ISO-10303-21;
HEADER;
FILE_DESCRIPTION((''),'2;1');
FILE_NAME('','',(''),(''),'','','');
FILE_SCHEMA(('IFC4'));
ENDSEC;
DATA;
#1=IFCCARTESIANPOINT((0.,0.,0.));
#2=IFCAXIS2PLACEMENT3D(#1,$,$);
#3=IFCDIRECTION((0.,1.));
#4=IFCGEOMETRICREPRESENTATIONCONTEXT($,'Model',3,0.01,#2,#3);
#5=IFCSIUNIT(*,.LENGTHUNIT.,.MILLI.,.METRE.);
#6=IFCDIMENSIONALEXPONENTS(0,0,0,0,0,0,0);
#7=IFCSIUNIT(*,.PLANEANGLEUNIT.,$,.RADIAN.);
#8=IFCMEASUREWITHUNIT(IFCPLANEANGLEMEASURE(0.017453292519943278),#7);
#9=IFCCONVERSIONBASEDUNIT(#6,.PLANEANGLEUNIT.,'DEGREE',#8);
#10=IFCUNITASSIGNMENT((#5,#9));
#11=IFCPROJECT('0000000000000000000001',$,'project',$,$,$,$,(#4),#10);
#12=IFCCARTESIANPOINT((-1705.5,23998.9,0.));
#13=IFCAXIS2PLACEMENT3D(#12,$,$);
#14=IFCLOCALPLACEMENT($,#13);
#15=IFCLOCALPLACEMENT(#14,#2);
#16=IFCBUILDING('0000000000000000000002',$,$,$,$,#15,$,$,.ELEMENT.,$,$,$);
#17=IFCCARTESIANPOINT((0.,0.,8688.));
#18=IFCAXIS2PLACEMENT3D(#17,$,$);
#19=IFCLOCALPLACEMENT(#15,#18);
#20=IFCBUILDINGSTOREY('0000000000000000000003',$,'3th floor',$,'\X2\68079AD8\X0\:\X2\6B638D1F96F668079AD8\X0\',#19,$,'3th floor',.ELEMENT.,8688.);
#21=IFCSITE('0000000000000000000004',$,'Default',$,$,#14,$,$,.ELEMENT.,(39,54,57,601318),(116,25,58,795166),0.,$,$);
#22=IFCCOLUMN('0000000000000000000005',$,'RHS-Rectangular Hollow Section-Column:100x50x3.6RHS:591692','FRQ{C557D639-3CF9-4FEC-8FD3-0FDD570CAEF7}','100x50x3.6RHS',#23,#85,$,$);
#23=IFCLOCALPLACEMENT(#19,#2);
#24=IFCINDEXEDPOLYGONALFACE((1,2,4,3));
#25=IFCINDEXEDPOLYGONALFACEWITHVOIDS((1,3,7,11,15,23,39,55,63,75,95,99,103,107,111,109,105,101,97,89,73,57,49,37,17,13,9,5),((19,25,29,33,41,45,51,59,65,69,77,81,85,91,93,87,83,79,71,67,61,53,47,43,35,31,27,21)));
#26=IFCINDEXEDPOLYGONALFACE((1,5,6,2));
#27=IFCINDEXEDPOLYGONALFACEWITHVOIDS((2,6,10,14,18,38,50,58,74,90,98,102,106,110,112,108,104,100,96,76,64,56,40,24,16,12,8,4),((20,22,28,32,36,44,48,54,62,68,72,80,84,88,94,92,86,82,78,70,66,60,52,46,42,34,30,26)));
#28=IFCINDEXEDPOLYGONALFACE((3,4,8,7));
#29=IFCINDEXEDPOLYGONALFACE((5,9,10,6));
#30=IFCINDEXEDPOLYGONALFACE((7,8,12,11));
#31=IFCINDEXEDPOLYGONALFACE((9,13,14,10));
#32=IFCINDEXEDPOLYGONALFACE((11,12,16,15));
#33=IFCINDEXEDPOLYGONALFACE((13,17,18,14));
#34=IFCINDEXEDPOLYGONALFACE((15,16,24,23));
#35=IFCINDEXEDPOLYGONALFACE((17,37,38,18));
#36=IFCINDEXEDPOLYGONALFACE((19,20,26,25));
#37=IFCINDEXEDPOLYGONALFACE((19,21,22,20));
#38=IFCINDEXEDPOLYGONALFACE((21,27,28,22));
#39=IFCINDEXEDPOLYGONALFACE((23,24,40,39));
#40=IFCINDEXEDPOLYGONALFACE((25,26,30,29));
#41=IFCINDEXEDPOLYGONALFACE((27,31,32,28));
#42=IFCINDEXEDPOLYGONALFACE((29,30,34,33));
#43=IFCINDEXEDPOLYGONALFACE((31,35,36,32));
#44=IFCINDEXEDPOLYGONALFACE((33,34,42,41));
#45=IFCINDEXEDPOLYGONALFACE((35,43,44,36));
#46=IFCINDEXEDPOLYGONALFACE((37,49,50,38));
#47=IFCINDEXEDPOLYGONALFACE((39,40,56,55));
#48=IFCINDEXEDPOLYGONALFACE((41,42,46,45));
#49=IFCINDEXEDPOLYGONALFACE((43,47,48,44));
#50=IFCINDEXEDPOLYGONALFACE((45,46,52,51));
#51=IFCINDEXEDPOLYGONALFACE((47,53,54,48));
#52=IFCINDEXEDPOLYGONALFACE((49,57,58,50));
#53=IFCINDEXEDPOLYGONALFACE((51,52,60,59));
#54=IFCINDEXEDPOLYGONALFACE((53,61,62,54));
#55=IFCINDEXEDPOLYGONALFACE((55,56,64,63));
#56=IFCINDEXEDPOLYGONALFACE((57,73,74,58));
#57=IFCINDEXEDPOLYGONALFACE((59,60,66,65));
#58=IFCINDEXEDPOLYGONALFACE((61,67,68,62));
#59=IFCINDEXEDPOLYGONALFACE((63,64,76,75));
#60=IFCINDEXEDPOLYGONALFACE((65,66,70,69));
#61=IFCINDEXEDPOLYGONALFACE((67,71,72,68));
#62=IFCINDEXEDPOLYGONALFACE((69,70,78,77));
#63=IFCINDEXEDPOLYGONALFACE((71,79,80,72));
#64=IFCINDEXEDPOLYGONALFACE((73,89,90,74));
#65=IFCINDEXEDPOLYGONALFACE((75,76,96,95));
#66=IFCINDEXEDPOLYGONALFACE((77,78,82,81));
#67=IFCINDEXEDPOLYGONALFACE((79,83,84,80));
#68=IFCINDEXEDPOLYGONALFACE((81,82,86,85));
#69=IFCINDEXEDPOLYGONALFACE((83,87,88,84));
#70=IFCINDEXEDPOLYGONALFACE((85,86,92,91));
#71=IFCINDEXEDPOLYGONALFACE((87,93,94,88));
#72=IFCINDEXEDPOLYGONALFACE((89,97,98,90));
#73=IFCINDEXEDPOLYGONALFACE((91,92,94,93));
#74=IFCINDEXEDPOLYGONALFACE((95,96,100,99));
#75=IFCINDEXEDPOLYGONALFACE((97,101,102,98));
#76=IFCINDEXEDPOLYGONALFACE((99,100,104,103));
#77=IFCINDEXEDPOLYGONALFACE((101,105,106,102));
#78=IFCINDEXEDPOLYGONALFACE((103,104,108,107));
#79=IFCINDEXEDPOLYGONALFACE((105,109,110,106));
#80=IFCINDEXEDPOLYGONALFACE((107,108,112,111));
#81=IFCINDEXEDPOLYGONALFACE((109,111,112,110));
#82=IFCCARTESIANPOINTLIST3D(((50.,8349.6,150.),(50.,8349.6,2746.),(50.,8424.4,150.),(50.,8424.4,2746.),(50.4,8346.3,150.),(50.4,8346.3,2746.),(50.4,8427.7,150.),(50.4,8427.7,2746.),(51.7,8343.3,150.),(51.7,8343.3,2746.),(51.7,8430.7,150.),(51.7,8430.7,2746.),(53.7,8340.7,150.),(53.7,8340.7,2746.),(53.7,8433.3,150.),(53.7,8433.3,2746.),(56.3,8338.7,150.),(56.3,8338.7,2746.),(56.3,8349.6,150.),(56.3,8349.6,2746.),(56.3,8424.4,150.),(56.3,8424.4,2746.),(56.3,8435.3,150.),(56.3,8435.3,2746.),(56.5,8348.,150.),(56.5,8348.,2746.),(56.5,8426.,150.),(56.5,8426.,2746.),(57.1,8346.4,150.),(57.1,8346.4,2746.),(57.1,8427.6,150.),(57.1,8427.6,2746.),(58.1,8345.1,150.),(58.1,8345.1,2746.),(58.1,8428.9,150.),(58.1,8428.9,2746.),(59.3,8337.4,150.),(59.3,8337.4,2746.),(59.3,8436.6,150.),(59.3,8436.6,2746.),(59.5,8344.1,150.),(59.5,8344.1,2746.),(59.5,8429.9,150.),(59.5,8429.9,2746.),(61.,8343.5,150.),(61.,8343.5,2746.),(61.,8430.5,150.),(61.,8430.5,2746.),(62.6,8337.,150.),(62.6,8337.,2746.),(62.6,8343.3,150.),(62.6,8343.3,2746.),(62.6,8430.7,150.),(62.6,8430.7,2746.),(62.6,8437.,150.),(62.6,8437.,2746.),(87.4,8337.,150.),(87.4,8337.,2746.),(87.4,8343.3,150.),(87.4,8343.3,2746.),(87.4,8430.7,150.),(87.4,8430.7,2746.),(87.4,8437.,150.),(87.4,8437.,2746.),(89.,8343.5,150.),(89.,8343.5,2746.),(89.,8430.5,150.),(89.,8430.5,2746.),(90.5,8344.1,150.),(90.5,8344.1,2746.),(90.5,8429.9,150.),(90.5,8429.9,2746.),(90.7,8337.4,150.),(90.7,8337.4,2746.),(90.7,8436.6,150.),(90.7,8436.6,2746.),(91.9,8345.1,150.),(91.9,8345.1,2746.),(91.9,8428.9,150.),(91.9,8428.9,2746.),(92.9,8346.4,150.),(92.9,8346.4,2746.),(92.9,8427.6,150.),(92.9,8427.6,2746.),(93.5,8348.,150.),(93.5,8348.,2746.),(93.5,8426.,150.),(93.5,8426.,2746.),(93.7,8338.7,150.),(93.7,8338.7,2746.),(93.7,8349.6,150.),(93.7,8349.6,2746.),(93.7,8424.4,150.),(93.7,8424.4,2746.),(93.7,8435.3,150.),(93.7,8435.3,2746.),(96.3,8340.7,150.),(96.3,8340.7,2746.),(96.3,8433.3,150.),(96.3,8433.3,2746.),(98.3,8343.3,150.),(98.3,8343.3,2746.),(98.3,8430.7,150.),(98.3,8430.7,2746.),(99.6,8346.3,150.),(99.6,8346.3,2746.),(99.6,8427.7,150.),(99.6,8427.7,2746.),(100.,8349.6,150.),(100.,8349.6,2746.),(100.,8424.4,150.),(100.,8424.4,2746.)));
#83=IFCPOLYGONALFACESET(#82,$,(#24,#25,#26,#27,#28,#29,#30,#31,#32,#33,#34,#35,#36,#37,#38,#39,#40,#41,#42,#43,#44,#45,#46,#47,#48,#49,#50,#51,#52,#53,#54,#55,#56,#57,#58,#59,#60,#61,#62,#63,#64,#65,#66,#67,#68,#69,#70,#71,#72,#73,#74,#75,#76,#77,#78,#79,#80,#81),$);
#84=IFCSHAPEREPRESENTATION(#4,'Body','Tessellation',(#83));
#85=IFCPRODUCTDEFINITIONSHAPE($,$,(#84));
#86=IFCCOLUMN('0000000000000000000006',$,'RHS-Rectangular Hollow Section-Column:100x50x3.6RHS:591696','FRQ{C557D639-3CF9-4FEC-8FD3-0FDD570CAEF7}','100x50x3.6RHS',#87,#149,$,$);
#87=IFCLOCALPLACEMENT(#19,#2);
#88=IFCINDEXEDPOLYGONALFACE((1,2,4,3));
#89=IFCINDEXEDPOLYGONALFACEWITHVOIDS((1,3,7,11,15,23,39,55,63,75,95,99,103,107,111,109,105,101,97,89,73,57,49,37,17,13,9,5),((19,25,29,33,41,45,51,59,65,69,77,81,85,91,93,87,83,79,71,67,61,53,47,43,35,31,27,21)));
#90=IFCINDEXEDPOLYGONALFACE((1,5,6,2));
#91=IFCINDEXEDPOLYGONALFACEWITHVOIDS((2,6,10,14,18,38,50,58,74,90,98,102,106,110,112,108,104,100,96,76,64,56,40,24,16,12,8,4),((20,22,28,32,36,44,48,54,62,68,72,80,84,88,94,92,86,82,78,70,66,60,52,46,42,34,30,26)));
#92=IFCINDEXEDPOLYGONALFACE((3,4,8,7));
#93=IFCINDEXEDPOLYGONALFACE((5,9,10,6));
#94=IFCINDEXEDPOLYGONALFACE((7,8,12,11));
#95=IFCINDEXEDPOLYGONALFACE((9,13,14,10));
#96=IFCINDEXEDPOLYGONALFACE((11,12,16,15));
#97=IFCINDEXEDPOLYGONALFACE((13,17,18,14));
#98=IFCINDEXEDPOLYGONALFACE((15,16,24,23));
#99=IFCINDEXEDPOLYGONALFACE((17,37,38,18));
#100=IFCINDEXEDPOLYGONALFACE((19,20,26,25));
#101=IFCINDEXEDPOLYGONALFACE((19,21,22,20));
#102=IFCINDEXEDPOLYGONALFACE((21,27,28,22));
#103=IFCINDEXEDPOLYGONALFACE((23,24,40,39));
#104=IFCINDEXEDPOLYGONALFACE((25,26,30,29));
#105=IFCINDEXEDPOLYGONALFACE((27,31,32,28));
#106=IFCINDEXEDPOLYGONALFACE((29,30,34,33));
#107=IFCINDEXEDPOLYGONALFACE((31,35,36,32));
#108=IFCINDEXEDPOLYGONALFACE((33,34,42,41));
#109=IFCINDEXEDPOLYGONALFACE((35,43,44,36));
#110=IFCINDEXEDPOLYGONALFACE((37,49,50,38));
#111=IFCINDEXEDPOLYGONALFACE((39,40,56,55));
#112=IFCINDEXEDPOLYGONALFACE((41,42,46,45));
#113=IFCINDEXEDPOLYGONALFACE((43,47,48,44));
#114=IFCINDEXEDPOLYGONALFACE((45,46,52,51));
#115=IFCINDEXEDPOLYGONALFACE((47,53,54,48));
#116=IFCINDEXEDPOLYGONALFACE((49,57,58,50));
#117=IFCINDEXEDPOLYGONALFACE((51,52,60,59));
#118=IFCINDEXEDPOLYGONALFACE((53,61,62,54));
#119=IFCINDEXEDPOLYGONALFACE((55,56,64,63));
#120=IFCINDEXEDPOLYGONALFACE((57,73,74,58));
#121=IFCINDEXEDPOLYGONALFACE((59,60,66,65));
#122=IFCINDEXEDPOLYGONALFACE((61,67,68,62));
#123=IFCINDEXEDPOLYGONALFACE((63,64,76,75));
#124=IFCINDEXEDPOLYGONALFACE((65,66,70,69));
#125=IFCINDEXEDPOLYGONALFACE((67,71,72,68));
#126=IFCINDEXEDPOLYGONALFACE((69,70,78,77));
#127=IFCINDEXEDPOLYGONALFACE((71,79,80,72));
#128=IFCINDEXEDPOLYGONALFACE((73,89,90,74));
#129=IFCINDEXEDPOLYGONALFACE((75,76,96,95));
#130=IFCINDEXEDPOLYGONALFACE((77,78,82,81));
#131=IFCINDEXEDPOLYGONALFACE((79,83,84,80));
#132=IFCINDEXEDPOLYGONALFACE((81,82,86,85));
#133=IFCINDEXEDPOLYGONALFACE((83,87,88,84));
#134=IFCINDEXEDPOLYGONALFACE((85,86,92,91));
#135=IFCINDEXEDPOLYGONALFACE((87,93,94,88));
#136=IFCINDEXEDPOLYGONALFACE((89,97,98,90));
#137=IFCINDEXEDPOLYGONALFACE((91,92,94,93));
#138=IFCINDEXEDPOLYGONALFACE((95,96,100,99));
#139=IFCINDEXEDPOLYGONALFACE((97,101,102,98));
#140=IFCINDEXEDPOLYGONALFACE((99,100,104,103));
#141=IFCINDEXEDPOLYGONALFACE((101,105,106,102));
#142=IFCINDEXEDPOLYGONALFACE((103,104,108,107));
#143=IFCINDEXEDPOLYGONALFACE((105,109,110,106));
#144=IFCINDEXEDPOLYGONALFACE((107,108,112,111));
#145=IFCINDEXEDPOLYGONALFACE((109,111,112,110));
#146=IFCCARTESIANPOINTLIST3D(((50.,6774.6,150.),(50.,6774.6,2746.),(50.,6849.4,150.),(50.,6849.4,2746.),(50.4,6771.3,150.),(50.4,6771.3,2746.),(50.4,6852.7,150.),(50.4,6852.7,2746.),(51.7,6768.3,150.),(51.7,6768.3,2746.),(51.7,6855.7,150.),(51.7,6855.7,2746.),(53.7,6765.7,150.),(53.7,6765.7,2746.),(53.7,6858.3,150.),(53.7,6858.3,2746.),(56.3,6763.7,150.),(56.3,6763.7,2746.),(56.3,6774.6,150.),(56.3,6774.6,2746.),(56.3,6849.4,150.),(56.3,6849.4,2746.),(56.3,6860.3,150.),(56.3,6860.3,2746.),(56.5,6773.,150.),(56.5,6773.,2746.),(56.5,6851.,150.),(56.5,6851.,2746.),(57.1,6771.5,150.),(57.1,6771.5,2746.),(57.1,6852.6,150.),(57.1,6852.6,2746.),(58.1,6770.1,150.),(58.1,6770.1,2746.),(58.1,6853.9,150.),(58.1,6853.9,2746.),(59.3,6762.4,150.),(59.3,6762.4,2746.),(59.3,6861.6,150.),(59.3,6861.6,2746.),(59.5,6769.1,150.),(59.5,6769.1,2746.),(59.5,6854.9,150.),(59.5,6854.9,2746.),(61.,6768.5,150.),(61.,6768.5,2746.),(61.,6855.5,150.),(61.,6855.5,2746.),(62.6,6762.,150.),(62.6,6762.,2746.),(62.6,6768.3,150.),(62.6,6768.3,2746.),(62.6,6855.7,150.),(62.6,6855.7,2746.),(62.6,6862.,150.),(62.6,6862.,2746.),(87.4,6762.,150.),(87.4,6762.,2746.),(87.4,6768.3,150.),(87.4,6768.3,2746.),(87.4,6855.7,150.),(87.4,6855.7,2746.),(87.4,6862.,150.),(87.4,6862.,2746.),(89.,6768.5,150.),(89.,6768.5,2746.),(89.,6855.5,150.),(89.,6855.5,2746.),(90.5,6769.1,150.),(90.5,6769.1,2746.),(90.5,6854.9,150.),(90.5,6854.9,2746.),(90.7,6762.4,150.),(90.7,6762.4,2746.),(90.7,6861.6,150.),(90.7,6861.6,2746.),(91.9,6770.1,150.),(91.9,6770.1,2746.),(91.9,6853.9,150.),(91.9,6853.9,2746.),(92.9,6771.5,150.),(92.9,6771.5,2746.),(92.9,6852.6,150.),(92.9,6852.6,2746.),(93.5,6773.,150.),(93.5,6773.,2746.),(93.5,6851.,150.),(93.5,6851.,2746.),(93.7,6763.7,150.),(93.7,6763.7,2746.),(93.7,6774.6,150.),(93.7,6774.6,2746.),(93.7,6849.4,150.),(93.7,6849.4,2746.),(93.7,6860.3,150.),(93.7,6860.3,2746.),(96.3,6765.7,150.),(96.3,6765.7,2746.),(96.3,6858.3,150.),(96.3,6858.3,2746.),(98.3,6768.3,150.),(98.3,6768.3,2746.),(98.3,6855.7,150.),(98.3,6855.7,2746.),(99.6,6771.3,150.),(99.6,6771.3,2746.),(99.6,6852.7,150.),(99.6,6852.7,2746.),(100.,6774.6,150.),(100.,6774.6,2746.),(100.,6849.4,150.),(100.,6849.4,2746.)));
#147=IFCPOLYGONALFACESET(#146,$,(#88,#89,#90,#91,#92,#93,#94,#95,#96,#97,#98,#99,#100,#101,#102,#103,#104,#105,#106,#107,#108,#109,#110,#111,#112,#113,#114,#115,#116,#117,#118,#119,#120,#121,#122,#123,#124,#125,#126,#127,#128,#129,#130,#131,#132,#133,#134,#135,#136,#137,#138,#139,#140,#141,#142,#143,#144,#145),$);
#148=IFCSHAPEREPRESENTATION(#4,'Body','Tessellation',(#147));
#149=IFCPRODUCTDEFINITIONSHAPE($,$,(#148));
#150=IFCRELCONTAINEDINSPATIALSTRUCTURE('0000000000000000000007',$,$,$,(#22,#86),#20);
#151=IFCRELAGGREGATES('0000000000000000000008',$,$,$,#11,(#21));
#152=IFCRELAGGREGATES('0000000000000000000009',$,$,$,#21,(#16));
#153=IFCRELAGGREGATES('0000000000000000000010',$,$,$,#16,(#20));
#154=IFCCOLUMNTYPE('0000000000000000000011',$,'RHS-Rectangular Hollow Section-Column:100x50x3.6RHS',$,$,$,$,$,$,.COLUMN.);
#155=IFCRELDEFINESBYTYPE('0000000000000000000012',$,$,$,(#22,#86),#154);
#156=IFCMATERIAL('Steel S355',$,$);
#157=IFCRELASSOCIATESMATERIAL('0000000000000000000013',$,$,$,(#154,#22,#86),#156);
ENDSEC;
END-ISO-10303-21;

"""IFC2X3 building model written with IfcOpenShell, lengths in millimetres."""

from ifc_helpers import new_model, entity, si_unit, converted_unit, point, direction, frame, frame_2d, origin, origin_2d, place, context, project, spatial, circle_curve, line_curve, trimmed, segment, composite_curve, hollow_rectangle, outline, extrude, clip, halfspace, material, type_object, element, save


model = new_model("IFC2X3")

# Units and contexts
model_context = context("Model", 3, precision=0.01, world=origin(), true_north=direction((0.0, 1.0)))
ifc_project = project(units=[si_unit("LENGTHUNIT", "METRE", prefix="MILLI"), converted_unit("PLANEANGLEUNIT", "DEGREE", entity("IfcPlaneAngleMeasure", 0.017453292519943278), si_unit("PLANEANGLEUNIT", "RADIAN"), dimensions=[0, 0, 0, 0, 0, 0, 0])], contexts=[model_context])

# Site, building, storey
site_placement = place(None, frame((-1705.5, 23998.9, 0.0)))
site = spatial("IfcSite", under=ifc_project, at=site_placement, Name="Default", CompositionType="ELEMENT", RefLatitude=(39, 54, 57, 601318), RefLongitude=(116, 25, 58, 795166), RefElevation=0.0)
building_placement = place(site_placement, origin())
building = spatial("IfcBuilding", under=site, at=building_placement, CompositionType="ELEMENT")
storey_placement = place(building_placement, frame((0.0, 0.0, 8688.0)))
storey = spatial("IfcBuildingStorey", under=building, at=storey_placement, Name="3th floor", ObjectType="标高:正负零标高", LongName="3th floor", CompositionType="ELEMENT", Elevation=8688.0)

# Columns, openings
ifc_material_1 = material(Name="Steel S355")
column_type_1 = type_object("IfcColumnType", Name="RHS-Rectangular Hollow Section-Column:100x50x3.6RHS", PredefinedType="COLUMN", material=ifc_material_1)
column_1_placement = place(storey_placement, frame((75.0, 8387.0, 2876.9)))
column_1 = element("IfcColumn", 1, at=column_1_placement, inside=storey, type_object=column_type_1, material=ifc_material_1, Name="RHS-Rectangular Hollow Section-Column:100x50x3.6RHS:591692", Description="FRQ{C557D639-3CF9-4FEC-8FD3-0FDD570CAEF7}", ObjectType="100x50x3.6RHS", context=model_context, shape_type="Clipping", body=[
    clip(clip(extrude(hollow_rectangle(XDim=50.0, YDim=100.0, WallThickness=6.3, InnerFilletRadius=6.3, OuterFilletRadius=12.6, at=origin_2d()), origin(), (0.0, 0.0, -1.0), 2782.8), halfspace(frame((-75.0, -8387.0, -2726.9), z_axis=(0.0, 0.0, 1.0), x_axis=(1.0, 0.0, 0.0)), True)), halfspace(frame((-75.0, -8387.0, -55.9), z_axis=(0.0, 0.0, -1.0), x_axis=(-1.0, 0.0, 0.0)), True)),
])
opening_1_placement = place(column_1_placement, frame((0.0, -150.1, -130.9), z_axis=(0.0, 1.0, 0.0), x_axis=(-1.0, 0.0, 0.0)))
element("IfcOpeningElement", 2, at=opening_1_placement, cuts=column_1, ObjectType="Opening", context=model_context, shape_type="SweptSolid", body=[
    extrude(outline(composite_curve([segment(trimmed(circle_curve(frame_2d((43.0, 32.0), x_axis=(1.0, 0.0)), 32.0), [point((43.0, 0.0))], [point((75.0, 32.0))], True, "CARTESIAN"), True, "CONTINUOUS"), segment(trimmed(line_curve((75.0, 32.0), (0.0, 1.0), 86.0), [point((75.0, 32.0))], [point((75.0, 118.0))], True, "CARTESIAN"), True, "CONTINUOUS"), segment(trimmed(circle_curve(frame_2d((43.0, 118.0), x_axis=(1.0, 0.0)), 32.0), [point((75.0, 118.0))], [point((43.0, 150.0))], True, "CARTESIAN"), True, "CONTINUOUS"), segment(trimmed(line_curve((43.0, 150.0), (-1.0, 0.0), 86.0), [point((43.0, 150.0))], [point((-43.0, 150.0))], True, "CARTESIAN"), True, "CONTINUOUS"), segment(trimmed(circle_curve(frame_2d((-43.0, 118.0), x_axis=(1.0, 0.0)), 32.0), [point((-43.0, 150.0))], [point((-75.0, 118.0))], True, "CARTESIAN"), True, "CONTINUOUS"), segment(trimmed(line_curve((-75.0, 118.0), (0.0, -1.0), 86.0), [point((-75.0, 118.0))], [point((-75.0, 32.0))], True, "CARTESIAN"), True, "CONTINUOUS"), segment(trimmed(circle_curve(frame_2d((-43.0, 32.0), x_axis=(1.0, 0.0)), 32.0), [point((-75.0, 32.0))], [point((-43.0, 0.0))], True, "CARTESIAN"), True, "CONTINUOUS"), segment(trimmed(line_curve((-43.0, 0.0), (1.0, 0.0), 86.0), [point((-43.0, 0.0))], [point((43.0, 0.0))], True, "CARTESIAN"), True, "CONTINUOUS")], self_intersect="UNKNOWN")), origin(), (0.0, 0.0, 1.0), 300.2),
])
column_2_placement = place(storey_placement, frame((75.0, 6812.0, 2876.9)))
column_2 = element("IfcColumn", 3, at=column_2_placement, inside=storey, type_object=column_type_1, material=ifc_material_1, Name="RHS-Rectangular Hollow Section-Column:100x50x3.6RHS:591696", Description="FRQ{C557D639-3CF9-4FEC-8FD3-0FDD570CAEF7}", ObjectType="100x50x3.6RHS", context=model_context, shape_type="Clipping", body=[
    clip(clip(extrude(hollow_rectangle(XDim=50.0, YDim=100.0, WallThickness=6.3, InnerFilletRadius=6.3, OuterFilletRadius=12.6, at=origin_2d()), origin(), (0.0, 0.0, -1.0), 2782.8), halfspace(frame((-75.0, -6812.0, -2726.9), z_axis=(0.0, 0.0, 1.0), x_axis=(1.0, 0.0, 0.0)), True)), halfspace(frame((-75.0, -6812.0, -55.9), z_axis=(0.0, 0.0, -1.0), x_axis=(-1.0, 0.0, 0.0)), True)),
])
opening_2_placement = place(column_2_placement, frame((0.0, -150.1, -130.9), z_axis=(0.0, 1.0, 0.0), x_axis=(-1.0, 0.0, 0.0)))
element("IfcOpeningElement", 4, at=opening_2_placement, cuts=column_2, ObjectType="Opening", context=model_context, shape_type="SweptSolid", body=[
    extrude(outline(composite_curve([segment(trimmed(circle_curve(frame_2d((43.0, 32.0), x_axis=(1.0, 0.0)), 32.0), [point((43.0, 0.0))], [point((75.0, 32.0))], True, "CARTESIAN"), True, "CONTINUOUS"), segment(trimmed(line_curve((75.0, 32.0), (0.0, 1.0), 86.0), [point((75.0, 32.0))], [point((75.0, 118.0))], True, "CARTESIAN"), True, "CONTINUOUS"), segment(trimmed(circle_curve(frame_2d((43.0, 118.0), x_axis=(1.0, 0.0)), 32.0), [point((75.0, 118.0))], [point((43.0, 150.0))], True, "CARTESIAN"), True, "CONTINUOUS"), segment(trimmed(line_curve((43.0, 150.0), (-1.0, 0.0), 86.0), [point((43.0, 150.0))], [point((-43.0, 150.0))], True, "CARTESIAN"), True, "CONTINUOUS"), segment(trimmed(circle_curve(frame_2d((-43.0, 118.0), x_axis=(1.0, 0.0)), 32.0), [point((-43.0, 150.0))], [point((-75.0, 118.0))], True, "CARTESIAN"), True, "CONTINUOUS"), segment(trimmed(line_curve((-75.0, 118.0), (0.0, -1.0), 86.0), [point((-75.0, 118.0))], [point((-75.0, 32.0))], True, "CARTESIAN"), True, "CONTINUOUS"), segment(trimmed(circle_curve(frame_2d((-43.0, 32.0), x_axis=(1.0, 0.0)), 32.0), [point((-75.0, 32.0))], [point((-43.0, 0.0))], True, "CARTESIAN"), True, "CONTINUOUS"), segment(trimmed(line_curve((-43.0, 0.0), (1.0, 0.0), 86.0), [point((-43.0, 0.0))], [point((43.0, 0.0))], True, "CARTESIAN"), True, "CONTINUOUS")], self_intersect="UNKNOWN")), origin(), (0.0, 0.0, 1.0), 300.2),
])

save(model, "model.ifc")
